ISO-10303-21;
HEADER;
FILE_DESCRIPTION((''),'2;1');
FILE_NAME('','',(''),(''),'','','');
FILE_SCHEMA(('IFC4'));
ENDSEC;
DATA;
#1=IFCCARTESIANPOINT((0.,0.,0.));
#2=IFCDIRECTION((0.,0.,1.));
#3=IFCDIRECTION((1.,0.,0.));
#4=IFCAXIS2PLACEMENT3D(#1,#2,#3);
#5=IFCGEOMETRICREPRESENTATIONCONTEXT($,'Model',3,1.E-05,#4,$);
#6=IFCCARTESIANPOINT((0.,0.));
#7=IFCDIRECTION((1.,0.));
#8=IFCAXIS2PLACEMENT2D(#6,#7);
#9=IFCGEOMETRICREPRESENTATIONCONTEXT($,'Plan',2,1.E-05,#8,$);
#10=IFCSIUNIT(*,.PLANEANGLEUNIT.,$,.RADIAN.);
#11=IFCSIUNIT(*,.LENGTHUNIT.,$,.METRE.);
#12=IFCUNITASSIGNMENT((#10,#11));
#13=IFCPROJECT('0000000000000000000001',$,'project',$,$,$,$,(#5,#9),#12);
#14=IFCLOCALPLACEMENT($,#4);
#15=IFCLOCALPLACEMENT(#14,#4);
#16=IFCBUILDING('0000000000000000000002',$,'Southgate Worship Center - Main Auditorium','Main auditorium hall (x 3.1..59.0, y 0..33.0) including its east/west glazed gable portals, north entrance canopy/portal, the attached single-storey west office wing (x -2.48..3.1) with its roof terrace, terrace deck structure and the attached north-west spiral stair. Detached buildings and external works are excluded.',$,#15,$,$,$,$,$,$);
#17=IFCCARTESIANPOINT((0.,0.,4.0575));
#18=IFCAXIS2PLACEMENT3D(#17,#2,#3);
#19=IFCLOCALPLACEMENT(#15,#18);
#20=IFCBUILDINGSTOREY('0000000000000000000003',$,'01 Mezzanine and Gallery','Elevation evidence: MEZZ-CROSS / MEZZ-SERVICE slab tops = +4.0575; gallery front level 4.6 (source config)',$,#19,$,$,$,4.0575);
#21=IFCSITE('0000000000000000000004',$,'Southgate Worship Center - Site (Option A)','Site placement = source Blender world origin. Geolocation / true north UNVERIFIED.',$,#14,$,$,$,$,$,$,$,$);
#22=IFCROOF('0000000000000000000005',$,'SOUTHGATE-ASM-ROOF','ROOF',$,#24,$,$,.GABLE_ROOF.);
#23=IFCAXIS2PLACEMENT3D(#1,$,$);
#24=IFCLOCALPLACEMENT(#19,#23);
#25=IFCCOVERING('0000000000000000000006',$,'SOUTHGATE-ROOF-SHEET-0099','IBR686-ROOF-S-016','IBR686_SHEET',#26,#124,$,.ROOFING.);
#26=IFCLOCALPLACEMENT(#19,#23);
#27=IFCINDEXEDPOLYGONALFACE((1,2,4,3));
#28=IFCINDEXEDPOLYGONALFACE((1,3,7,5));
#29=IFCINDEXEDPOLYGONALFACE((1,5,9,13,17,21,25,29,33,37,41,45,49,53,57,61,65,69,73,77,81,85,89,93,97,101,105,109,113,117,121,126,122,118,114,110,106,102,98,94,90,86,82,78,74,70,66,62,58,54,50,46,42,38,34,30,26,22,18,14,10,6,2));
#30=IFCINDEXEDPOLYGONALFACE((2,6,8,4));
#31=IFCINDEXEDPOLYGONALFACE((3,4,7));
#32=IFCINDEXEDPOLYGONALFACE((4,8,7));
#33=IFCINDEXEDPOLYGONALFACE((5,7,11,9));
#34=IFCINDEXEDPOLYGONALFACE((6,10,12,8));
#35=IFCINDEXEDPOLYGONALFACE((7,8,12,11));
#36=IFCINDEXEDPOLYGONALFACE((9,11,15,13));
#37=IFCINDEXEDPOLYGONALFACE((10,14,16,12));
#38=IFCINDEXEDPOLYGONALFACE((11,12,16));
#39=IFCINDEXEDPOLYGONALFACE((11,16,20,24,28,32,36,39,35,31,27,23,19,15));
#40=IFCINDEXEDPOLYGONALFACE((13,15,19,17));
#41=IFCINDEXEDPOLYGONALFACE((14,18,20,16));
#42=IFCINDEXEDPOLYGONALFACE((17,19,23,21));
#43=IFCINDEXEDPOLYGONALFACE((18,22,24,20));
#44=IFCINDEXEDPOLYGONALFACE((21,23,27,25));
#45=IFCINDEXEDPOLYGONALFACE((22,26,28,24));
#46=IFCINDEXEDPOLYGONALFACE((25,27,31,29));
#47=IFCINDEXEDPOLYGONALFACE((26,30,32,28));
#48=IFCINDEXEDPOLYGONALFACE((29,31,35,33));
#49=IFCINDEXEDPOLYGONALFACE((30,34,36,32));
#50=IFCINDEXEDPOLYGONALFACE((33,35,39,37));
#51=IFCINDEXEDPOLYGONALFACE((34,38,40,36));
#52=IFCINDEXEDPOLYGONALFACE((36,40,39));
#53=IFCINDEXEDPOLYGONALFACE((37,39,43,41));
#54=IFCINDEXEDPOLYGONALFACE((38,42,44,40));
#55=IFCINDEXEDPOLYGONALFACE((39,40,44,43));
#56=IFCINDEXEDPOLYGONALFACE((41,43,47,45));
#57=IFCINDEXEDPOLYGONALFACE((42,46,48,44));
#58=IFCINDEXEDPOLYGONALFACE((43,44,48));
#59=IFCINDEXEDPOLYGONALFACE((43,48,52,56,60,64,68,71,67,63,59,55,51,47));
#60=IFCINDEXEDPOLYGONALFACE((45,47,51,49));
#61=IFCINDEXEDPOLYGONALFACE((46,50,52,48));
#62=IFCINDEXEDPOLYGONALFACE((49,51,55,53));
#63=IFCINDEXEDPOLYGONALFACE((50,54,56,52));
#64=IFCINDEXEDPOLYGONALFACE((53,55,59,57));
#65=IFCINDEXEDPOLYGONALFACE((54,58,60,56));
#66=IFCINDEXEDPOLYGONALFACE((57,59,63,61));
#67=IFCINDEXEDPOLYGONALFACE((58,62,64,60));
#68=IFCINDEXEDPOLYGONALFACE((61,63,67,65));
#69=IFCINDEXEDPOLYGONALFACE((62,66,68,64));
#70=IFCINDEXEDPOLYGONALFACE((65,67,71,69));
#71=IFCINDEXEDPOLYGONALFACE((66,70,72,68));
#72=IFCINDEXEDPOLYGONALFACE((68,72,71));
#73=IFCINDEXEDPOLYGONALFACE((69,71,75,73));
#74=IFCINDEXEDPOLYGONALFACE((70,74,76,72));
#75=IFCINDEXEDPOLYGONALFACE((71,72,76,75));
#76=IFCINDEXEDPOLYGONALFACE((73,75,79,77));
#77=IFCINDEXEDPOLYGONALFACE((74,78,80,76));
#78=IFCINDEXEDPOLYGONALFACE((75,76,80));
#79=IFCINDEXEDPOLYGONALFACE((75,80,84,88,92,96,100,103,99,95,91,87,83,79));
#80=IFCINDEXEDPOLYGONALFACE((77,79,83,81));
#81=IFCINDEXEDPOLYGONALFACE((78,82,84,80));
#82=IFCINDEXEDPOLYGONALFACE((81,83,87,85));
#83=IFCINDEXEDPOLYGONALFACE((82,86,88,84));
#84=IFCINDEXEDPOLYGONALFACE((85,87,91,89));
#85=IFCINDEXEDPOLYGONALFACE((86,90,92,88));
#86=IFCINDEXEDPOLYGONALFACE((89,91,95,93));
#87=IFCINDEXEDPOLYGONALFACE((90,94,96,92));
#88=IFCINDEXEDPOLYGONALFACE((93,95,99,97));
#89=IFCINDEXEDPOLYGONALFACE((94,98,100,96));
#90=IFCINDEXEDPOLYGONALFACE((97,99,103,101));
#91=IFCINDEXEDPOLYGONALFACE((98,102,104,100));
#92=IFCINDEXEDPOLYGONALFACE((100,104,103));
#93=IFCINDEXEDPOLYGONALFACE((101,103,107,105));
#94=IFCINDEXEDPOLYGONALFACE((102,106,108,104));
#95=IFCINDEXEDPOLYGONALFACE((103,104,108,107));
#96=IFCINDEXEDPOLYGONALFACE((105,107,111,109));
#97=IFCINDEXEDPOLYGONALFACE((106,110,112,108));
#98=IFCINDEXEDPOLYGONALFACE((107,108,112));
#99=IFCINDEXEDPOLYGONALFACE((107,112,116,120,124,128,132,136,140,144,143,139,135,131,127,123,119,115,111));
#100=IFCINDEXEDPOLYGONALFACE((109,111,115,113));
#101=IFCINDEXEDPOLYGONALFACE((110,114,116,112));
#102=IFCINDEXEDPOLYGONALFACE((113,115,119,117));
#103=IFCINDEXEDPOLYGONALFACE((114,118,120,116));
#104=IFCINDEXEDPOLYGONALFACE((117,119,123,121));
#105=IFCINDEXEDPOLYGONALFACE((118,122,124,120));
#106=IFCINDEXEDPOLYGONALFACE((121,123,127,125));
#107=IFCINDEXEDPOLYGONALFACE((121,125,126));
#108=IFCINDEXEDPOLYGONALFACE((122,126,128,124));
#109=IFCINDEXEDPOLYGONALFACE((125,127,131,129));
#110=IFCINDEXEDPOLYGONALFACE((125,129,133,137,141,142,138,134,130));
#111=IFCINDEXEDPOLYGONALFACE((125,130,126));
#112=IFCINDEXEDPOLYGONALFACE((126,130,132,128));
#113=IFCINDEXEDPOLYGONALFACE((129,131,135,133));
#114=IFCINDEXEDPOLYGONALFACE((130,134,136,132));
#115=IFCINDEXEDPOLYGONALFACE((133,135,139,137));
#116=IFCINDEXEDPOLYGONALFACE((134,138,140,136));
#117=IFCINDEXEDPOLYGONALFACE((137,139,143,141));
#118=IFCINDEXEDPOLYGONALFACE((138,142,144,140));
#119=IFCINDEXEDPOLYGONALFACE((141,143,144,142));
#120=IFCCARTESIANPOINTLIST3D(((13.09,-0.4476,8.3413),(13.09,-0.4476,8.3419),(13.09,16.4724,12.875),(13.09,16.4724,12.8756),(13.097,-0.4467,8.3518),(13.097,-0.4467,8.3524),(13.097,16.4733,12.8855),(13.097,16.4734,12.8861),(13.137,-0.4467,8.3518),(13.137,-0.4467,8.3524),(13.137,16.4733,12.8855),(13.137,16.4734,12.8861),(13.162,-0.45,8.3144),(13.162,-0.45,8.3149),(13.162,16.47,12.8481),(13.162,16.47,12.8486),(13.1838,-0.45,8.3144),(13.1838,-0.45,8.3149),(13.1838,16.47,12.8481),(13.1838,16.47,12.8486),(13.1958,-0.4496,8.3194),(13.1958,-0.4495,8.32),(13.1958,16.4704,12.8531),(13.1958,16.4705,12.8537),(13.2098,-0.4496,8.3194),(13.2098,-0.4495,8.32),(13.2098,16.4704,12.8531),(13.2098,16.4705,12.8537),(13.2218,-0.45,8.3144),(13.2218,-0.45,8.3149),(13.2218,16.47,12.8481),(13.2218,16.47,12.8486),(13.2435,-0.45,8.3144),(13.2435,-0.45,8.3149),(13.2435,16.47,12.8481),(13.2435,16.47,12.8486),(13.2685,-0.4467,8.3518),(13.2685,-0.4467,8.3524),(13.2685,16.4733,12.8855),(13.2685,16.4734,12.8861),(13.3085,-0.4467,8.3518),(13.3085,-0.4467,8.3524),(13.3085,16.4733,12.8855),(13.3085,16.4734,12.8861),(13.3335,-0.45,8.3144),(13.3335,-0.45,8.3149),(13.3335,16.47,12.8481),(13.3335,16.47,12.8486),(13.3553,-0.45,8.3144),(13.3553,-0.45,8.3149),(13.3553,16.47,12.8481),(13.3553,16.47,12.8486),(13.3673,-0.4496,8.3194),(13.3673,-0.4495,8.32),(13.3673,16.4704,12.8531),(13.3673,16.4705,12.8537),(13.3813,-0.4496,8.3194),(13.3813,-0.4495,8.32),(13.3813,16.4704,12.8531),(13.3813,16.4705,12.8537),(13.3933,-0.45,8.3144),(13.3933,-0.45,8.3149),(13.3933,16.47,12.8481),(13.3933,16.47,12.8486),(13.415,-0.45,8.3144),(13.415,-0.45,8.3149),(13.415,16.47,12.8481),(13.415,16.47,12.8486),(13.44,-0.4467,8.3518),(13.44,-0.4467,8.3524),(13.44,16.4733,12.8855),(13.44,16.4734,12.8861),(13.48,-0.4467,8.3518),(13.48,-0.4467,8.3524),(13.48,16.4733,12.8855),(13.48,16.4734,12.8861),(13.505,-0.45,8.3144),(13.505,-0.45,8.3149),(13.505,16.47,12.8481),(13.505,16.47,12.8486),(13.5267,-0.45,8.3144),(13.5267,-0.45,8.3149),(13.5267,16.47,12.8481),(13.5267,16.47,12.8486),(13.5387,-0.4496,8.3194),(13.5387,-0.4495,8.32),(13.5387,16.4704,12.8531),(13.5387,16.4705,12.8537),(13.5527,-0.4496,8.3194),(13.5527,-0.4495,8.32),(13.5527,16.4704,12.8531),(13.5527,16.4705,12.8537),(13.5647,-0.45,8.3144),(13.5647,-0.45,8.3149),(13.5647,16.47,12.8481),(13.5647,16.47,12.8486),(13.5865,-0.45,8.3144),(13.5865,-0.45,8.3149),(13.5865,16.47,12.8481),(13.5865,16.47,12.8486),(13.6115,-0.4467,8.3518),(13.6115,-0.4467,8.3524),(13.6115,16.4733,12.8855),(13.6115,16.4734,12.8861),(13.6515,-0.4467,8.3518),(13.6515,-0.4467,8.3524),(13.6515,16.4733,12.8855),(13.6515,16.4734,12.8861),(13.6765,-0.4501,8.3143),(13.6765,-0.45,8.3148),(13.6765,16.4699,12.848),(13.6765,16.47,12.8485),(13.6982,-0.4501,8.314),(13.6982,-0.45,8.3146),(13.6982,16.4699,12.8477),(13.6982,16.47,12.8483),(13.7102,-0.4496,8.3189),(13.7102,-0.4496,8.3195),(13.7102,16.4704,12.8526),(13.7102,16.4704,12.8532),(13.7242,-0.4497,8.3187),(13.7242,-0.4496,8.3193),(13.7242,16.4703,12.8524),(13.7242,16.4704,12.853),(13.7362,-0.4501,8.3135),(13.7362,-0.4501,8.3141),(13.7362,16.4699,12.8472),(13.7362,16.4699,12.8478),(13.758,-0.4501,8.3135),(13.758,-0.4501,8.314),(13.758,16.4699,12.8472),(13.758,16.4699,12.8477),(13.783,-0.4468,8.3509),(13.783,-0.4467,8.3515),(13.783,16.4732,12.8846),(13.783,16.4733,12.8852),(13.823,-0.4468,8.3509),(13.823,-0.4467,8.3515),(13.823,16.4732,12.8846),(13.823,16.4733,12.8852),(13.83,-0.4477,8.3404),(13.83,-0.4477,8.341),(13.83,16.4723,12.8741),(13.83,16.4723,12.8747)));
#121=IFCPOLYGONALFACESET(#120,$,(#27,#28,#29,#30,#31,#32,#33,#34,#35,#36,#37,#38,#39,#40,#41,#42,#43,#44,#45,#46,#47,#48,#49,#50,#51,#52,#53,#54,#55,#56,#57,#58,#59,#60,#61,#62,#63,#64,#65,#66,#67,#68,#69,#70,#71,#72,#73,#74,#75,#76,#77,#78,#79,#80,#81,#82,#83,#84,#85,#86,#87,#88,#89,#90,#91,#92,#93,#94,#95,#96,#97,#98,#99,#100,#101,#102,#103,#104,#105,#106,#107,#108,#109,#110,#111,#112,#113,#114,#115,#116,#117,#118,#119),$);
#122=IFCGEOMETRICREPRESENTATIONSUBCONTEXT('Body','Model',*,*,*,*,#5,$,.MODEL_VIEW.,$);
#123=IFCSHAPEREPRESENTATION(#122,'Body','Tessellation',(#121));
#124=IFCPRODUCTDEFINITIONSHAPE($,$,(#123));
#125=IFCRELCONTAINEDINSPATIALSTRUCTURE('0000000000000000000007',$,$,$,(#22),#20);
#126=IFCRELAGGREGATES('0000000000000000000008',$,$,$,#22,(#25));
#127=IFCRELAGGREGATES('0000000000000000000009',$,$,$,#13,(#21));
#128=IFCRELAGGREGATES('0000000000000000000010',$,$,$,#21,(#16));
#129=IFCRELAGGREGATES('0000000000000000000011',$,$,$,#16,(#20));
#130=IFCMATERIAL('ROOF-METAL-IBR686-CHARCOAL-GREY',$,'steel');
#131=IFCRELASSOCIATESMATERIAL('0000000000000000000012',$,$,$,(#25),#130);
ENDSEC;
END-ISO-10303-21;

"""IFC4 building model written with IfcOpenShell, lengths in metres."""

from ifc_helpers import new_model, si_unit, frame, origin_with_axes, origin_2d_with_axis, place, context, subcontext, project, spatial, indexed_curve, outline, extrude, clip, halfspace, material, element, aggregate, save


model = new_model("IFC4")

# Units and contexts
model_context = context("Model", 3, precision=1e-05, world=origin_with_axes())
plan_context = context("Plan", 2, precision=1e-05, world=origin_2d_with_axis())
body_context = subcontext(model_context, "Body", "Model", "MODEL_VIEW")
ifc_project = project(units=[si_unit("PLANEANGLEUNIT", "RADIAN"), si_unit("LENGTHUNIT", "METRE")], contexts=[model_context, plan_context])

# Site, building, storey
site_placement = place(None, origin_with_axes())
site = spatial("IfcSite", under=ifc_project, at=site_placement, Name="Southgate Worship Center - Site (Option A)", Description="Site placement = source Blender world origin. Geolocation / true north UNVERIFIED.")
building_placement = place(site_placement, origin_with_axes())
building = spatial("IfcBuilding", under=site, at=building_placement, Name="Southgate Worship Center - Main Auditorium", Description="Main auditorium hall (x 3.1..59.0, y 0..33.0) including its east/west glazed gable portals, north entrance canopy/portal, the attached single-storey west office wing (x -2.48..3.1) with its roof terrace, terrace deck structure and the attached north-west spiral stair. Detached buildings and external works are excluded.")
storey_placement = place(building_placement, frame((0.0, 0.0, 4.0575), z_axis=(0.0, 0.0, 1.0), x_axis=(1.0, 0.0, 0.0)))
storey = spatial("IfcBuildingStorey", under=building, at=storey_placement, Name="01 Mezzanine and Gallery", Description="Elevation evidence: MEZZ-CROSS / MEZZ-SERVICE slab tops = +4.0575; gallery front level 4.6 (source config)", Elevation=4.0575)

# Roof, covering
roof_placement = place(storey_placement, origin_with_axes())
roof = element("IfcRoof", 1, at=roof_placement, inside=storey, Name="SOUTHGATE-ASM-ROOF", Description="ROOF", PredefinedType="GABLE_ROOF")
ifc_material_1 = material(Name="ROOF-METAL-IBR686-CHARCOAL-GREY", Category="steel")
covering_1_placement = place(roof_placement, frame((13.09, -0.4501, 8.3135), z_axis=(0.0, 0.0, 1.0), x_axis=(1.0, 0.0, 0.0)))
covering_1 = element("IfcCovering", 2, at=covering_1_placement, material=ifc_material_1, Name="SOUTHGATE-ROOF-SHEET-0099", Description="IBR686-ROOF-S-016", ObjectType="IBR686_SHEET", PredefinedType="ROOFING", context=body_context, shape_type="Clipping", body=[
    clip(clip(extrude(outline(indexed_curve([(0.0, 0.0), (0.025, 0.0353), (0.065, 0.0353), (0.072, 0.0254), (0.072, 0.0259), (0.065, 0.0358), (0.025, 0.0358), (0.0, 0.0005), (-0.0218, 0.0005), (-0.0338, 0.0053), (-0.0478, 0.0053), (-0.0598, 0.0005), (-0.0815, 0.0005), (-0.1065, 0.0358), (-0.1465, 0.0358), (-0.1715, 0.0005), (-0.1933, 0.0005), (-0.2053, 0.0053), (-0.2193, 0.0053), (-0.2313, 0.0005), (-0.253, 0.0005), (-0.278, 0.0358), (-0.318, 0.0358), (-0.343, 0.0005), (-0.3647, 0.0005), (-0.3767, 0.0053), (-0.3907, 0.0053), (-0.4028, 0.0005), (-0.4245, 0.0005), (-0.4495, 0.0358), (-0.4895, 0.0358), (-0.5145, 0.0004), (-0.5363, 0.0002), (-0.5483, 0.0048), (-0.5623, 0.0046), (-0.5743, -0.0003), (-0.596, -0.0004), (-0.621, 0.0349), (-0.661, 0.0349), (-0.668, 0.0251), (-0.668, 0.0246), (-0.661, 0.0344), (-0.621, 0.0344), (-0.596, -0.0009), (-0.5743, -0.0008), (-0.5623, 0.0041), (-0.5483, 0.0043), (-0.5363, -0.0003), (-0.5145, -0.0001), (-0.4895, 0.0353), (-0.4495, 0.0353), (-0.4245, 0.0), (-0.4028, 0.0), (-0.3907, 0.0048), (-0.3767, 0.0048), (-0.3647, 0.0), (-0.343, 0.0), (-0.318, 0.0353), (-0.278, 0.0353), (-0.253, 0.0), (-0.2313, 0.0), (-0.2193, 0.0048), (-0.2053, 0.0048), (-0.1933, 0.0), (-0.1715, 0.0), (-0.1465, 0.0353), (-0.1065, 0.0353), (-0.0815, 0.0), (-0.0598, 0.0), (-0.0478, 0.0048), (-0.0338, 0.0048), (-0.0218, 0.0), (0.0, 0.0)], self_intersect=False)), frame((0.072, -0.0003, 0.0008), z_axis=(0.0, 0.965926, 0.258819), x_axis=(-1.0, 0.0, 0.0)), (0.0, 0.0, 1.0), 17.5303), halfspace(frame((0.37, 0.0012, 0.014), z_axis=(0.0, -0.996022, 0.089113), x_axis=(1.0, 0.0, 0.0)), False)), halfspace(frame((0.37, 16.9212, 4.5477), z_axis=(0.0, 0.996021, -0.089119), x_axis=(-1.0, 0.0, 0.0)), False)),
])
aggregate(roof, [covering_1])

save(model, "model.ifc")
